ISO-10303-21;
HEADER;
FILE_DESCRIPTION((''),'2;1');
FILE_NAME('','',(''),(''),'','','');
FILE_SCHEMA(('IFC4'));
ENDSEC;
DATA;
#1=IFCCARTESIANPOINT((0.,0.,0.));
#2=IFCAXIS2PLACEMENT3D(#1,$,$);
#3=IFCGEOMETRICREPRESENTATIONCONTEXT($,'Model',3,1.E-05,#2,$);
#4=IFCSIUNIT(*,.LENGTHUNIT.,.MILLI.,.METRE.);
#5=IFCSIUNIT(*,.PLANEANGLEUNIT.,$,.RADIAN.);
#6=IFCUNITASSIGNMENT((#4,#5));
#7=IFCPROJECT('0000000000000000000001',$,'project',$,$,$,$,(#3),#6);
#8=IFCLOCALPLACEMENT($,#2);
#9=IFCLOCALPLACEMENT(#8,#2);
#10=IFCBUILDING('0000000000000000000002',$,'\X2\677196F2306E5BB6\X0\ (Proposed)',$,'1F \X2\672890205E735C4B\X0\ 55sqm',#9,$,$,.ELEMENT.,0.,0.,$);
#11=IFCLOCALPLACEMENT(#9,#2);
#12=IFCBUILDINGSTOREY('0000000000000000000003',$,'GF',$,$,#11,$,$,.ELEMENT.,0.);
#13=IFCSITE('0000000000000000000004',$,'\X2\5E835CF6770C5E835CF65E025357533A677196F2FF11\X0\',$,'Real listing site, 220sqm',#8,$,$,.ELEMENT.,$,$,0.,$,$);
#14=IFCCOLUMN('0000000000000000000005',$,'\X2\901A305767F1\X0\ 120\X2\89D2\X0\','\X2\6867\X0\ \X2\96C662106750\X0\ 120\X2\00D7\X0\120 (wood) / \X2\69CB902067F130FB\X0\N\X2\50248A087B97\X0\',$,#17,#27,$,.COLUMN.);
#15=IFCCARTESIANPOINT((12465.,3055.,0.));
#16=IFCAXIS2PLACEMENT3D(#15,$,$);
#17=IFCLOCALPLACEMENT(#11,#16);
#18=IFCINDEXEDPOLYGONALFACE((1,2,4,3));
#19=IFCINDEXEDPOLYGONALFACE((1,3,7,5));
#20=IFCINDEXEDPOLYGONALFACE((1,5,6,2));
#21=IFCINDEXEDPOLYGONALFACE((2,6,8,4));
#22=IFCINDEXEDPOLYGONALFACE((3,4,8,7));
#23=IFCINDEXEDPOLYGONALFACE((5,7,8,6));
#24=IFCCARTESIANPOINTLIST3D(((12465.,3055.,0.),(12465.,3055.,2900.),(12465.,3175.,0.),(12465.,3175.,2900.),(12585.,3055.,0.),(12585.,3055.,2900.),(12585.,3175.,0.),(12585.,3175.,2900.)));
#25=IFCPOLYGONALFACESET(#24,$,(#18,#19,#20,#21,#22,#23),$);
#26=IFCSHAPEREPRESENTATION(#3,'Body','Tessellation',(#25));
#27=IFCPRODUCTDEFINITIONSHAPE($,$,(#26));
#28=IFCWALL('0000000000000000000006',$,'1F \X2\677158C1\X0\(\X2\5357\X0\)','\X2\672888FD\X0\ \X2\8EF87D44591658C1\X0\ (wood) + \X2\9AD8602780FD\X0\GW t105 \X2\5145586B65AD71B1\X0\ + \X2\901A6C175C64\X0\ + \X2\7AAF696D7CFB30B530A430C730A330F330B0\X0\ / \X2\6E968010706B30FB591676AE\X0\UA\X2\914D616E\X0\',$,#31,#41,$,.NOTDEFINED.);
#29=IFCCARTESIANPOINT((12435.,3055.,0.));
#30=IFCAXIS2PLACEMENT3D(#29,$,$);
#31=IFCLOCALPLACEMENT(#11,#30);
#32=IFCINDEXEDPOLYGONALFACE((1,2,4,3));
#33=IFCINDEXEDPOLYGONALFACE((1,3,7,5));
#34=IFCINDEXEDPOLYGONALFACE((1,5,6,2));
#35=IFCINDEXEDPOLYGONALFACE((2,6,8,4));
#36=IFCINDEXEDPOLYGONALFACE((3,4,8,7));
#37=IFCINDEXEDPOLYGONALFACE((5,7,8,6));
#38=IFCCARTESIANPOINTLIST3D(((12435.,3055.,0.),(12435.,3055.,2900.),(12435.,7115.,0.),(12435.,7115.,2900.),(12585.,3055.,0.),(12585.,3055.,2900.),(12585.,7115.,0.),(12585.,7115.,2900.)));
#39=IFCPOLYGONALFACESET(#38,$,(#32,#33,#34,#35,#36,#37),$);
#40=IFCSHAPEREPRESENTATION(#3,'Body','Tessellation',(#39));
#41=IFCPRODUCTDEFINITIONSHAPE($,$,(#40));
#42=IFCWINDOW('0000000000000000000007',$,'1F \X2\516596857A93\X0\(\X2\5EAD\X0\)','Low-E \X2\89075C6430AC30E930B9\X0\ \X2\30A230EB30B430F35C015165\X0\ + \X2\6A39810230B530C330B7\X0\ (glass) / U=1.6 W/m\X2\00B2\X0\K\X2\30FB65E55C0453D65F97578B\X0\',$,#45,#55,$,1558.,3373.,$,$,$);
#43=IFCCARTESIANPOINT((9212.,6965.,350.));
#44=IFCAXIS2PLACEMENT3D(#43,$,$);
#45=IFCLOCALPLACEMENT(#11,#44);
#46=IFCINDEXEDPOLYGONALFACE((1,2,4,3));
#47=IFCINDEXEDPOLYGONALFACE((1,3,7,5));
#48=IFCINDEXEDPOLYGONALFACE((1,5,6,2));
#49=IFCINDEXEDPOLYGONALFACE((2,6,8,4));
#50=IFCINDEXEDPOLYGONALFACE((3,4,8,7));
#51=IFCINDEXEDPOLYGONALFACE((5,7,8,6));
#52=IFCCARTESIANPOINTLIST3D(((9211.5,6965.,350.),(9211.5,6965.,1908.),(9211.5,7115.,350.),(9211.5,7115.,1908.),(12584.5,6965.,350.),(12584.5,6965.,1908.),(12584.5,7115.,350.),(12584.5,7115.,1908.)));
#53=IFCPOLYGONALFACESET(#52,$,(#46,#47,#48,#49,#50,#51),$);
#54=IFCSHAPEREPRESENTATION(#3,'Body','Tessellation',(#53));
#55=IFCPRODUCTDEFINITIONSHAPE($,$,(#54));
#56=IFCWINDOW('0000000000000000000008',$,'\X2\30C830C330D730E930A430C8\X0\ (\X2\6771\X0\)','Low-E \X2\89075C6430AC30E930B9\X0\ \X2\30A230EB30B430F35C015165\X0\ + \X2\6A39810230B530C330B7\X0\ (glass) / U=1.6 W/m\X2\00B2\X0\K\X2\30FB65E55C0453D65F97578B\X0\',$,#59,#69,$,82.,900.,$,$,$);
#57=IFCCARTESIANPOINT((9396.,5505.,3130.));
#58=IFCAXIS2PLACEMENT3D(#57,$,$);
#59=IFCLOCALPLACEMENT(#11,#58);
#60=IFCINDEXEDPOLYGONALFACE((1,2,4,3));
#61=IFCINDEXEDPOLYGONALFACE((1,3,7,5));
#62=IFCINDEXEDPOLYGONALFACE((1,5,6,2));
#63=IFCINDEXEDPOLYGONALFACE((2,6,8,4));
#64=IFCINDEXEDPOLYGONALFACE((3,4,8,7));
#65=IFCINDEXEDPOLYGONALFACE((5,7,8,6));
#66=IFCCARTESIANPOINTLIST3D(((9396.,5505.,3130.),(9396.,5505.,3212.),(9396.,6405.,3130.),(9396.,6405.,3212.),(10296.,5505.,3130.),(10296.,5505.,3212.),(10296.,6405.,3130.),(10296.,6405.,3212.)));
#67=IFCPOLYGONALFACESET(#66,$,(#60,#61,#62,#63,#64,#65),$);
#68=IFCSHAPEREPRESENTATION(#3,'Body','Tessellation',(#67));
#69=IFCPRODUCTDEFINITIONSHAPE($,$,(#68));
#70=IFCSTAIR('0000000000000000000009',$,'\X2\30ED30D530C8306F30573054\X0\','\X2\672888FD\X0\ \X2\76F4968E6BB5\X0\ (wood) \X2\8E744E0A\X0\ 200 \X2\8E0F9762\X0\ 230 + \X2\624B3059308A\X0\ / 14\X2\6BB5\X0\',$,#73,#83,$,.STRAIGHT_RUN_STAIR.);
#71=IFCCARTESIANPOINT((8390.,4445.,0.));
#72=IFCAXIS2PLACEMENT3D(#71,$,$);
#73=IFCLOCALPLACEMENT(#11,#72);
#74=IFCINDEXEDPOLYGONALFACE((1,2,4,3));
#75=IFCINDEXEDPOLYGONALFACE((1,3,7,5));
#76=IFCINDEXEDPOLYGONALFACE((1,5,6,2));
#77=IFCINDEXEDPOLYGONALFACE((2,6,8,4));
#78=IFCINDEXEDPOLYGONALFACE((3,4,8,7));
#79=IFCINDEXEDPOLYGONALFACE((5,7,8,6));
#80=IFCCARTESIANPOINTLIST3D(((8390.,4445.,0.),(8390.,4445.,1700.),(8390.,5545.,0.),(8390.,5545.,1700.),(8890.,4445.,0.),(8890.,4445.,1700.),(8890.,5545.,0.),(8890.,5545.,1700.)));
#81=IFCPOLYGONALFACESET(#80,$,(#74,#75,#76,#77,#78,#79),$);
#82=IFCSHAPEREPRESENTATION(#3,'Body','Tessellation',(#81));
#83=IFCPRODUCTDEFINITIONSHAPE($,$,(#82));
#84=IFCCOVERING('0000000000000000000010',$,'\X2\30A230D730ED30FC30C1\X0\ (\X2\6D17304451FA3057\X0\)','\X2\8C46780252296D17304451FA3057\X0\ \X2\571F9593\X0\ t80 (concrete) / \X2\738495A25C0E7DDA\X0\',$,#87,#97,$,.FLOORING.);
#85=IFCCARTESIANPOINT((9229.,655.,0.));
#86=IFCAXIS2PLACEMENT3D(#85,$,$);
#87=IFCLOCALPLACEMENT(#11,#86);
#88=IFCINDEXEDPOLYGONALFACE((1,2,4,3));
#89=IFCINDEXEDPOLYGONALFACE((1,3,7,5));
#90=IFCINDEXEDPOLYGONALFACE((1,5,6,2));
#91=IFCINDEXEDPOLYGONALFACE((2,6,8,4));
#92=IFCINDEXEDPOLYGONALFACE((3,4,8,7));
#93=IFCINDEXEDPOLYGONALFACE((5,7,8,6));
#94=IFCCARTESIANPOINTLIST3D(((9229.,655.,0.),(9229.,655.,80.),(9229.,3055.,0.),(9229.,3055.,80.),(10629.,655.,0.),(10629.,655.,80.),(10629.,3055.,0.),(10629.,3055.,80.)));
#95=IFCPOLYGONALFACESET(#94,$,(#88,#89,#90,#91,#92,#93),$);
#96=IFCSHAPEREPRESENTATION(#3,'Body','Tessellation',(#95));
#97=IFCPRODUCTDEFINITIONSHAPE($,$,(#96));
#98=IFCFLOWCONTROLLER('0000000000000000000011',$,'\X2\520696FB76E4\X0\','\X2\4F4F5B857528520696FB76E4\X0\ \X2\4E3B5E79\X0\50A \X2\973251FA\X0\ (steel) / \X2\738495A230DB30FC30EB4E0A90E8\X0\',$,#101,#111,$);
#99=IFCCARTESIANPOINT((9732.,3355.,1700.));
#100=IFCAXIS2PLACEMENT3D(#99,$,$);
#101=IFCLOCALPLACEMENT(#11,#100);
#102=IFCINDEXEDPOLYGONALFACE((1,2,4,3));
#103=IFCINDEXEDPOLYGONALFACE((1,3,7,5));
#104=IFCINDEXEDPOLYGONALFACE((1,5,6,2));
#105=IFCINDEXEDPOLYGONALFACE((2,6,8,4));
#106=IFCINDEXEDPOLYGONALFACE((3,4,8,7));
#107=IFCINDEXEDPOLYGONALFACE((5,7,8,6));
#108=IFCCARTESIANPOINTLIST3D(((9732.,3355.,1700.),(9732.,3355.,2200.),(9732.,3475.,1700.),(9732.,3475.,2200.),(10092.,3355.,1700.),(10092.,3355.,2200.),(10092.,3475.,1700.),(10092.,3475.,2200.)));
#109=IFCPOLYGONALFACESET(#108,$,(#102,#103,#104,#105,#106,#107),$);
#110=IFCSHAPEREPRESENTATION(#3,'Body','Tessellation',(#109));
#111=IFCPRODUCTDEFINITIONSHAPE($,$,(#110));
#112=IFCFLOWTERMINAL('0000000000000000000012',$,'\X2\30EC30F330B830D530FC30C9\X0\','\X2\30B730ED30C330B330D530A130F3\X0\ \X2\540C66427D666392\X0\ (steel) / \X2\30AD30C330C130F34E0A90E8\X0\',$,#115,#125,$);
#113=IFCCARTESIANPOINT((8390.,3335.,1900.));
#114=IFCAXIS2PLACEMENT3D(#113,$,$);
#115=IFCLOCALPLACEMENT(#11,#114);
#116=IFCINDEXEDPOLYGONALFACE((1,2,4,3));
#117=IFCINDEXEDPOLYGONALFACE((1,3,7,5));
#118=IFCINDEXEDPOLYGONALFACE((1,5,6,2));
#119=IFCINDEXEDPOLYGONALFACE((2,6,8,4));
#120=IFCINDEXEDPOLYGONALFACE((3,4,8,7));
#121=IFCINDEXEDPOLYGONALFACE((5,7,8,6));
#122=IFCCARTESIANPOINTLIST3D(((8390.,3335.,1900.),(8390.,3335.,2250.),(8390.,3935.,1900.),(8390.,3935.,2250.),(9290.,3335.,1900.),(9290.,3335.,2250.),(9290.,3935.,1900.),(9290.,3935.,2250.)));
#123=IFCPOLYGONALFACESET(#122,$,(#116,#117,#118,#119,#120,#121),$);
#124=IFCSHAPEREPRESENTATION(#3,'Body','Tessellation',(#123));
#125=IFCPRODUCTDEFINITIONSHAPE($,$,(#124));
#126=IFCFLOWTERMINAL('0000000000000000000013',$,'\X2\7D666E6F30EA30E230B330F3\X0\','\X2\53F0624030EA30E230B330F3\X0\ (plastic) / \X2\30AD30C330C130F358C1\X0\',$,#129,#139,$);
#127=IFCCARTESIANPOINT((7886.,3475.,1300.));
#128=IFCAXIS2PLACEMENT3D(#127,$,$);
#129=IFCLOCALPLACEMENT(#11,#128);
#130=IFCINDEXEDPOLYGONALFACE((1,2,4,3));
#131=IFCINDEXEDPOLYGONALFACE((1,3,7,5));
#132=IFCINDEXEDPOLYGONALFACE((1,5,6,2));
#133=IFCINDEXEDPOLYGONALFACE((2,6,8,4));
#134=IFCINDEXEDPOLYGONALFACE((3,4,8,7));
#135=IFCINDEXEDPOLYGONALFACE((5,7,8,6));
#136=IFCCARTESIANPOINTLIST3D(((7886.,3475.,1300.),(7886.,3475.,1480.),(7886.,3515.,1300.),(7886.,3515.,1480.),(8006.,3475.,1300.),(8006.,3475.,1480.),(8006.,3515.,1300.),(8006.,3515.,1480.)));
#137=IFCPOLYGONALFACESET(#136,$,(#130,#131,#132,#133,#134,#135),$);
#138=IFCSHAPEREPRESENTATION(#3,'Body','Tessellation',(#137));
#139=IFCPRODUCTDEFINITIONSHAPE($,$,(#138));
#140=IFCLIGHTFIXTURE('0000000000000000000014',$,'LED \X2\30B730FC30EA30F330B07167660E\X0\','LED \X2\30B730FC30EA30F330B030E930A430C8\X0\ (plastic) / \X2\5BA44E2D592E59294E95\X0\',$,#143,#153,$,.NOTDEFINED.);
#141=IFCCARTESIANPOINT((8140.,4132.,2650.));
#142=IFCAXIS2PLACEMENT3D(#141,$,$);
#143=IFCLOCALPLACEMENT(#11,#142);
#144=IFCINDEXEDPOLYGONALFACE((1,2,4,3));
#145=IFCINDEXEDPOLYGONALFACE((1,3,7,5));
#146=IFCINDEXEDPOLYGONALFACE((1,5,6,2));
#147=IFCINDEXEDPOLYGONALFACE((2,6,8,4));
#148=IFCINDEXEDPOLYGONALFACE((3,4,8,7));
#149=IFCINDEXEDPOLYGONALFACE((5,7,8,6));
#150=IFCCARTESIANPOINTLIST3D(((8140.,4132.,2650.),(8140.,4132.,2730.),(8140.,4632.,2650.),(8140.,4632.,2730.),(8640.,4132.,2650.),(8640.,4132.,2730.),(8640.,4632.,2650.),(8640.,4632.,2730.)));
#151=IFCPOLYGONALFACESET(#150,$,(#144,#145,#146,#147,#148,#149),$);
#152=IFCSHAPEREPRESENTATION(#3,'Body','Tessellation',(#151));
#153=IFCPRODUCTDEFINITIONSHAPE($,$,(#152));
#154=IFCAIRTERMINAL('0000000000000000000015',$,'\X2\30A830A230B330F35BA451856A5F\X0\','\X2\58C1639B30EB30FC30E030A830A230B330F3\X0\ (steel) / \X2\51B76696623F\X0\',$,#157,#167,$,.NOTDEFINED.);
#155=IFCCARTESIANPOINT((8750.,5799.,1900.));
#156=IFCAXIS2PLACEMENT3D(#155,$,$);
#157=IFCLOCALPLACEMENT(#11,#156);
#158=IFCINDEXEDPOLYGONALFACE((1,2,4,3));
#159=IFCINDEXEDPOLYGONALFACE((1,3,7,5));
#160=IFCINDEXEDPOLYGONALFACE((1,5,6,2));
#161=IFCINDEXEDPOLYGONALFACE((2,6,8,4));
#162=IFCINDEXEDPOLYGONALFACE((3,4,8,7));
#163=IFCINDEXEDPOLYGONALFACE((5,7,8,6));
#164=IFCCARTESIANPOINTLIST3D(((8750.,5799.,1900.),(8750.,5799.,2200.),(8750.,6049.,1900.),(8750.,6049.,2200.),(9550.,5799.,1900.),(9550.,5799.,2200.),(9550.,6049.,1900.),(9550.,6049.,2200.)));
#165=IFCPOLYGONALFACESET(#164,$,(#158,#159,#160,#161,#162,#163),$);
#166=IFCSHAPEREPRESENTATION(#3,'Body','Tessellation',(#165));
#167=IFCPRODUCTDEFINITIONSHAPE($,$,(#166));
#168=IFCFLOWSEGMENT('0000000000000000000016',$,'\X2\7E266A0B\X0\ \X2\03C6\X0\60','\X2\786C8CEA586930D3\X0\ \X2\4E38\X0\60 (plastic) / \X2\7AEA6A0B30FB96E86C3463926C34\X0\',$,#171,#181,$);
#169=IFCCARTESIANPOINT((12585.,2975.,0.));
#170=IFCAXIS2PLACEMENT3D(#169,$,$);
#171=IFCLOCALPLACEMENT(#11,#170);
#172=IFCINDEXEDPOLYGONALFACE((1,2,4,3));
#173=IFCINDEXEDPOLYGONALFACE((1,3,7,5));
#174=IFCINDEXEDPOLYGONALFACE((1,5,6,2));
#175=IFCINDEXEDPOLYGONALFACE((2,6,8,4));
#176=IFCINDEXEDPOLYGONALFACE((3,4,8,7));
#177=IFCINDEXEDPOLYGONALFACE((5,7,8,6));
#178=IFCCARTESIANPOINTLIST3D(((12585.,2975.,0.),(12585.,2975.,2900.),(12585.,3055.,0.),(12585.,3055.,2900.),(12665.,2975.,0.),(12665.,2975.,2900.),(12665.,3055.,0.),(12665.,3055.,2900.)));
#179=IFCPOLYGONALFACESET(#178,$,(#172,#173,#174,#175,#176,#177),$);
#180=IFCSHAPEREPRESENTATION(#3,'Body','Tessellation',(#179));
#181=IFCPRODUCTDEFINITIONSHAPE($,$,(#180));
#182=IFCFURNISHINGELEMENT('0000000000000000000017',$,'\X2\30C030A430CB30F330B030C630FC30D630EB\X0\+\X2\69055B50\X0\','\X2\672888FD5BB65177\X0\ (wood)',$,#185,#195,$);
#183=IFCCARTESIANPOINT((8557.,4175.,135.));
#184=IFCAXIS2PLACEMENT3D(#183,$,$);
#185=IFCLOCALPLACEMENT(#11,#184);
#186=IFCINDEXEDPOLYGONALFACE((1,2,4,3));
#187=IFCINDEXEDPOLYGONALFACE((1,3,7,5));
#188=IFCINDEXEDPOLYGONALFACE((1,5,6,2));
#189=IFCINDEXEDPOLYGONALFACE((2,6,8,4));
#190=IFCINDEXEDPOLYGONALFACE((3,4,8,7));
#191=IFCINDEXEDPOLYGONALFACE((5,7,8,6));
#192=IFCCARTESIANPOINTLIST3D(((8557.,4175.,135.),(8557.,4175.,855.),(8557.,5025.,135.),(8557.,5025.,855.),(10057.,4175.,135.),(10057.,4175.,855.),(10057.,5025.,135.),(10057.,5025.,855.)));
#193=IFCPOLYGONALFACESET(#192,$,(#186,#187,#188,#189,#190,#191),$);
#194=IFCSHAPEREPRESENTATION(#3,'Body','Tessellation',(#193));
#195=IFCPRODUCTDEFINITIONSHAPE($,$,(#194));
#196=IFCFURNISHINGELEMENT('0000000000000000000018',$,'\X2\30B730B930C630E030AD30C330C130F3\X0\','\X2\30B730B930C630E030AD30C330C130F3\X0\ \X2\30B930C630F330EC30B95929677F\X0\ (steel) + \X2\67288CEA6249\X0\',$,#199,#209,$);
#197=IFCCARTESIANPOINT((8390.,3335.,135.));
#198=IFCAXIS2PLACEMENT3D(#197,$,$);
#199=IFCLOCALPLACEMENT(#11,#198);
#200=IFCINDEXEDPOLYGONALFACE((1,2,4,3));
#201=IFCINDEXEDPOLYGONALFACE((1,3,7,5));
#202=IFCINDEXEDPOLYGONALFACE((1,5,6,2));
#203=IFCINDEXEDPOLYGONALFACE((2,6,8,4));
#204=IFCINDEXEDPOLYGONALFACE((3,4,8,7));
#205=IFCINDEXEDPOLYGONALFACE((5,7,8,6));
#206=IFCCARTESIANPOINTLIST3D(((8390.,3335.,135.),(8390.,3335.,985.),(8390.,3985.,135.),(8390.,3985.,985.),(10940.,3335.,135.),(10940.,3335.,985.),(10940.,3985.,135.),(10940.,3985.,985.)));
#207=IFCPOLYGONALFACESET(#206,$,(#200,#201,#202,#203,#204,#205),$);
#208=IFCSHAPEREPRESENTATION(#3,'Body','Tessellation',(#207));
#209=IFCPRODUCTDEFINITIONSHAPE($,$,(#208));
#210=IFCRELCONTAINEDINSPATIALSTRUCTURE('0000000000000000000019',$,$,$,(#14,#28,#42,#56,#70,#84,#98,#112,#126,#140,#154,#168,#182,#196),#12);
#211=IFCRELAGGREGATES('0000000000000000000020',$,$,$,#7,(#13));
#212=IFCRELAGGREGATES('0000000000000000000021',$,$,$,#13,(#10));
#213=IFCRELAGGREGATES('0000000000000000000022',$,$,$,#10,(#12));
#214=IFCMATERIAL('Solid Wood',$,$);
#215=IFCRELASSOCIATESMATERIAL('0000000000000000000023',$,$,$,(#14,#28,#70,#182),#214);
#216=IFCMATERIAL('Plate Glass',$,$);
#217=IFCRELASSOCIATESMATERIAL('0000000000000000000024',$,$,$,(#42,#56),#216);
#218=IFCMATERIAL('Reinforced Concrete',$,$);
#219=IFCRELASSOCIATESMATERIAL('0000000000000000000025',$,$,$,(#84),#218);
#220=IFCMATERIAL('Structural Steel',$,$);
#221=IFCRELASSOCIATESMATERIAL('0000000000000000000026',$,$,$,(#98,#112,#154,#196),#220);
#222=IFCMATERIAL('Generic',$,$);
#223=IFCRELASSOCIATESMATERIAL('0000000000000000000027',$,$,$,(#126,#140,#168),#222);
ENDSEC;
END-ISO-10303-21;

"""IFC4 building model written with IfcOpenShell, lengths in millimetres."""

from ifc_helpers import new_model, si_unit, frame, frame_2d, origin, place, context, project, spatial, rectangle, extrude, material, element, fill, save


model = new_model("IFC4")

# Units and contexts
model_context = context("Model", 3, precision=1e-05, world=origin())
ifc_project = project(units=[si_unit("LENGTHUNIT", "METRE", prefix="MILLI"), si_unit("PLANEANGLEUNIT", "RADIAN")], contexts=[model_context])

# Site, building, storey
site_placement = place(None, origin())
site = spatial("IfcSite", under=ifc_project, at=site_placement, Name="広島県広島市南区東雲１", ObjectType="Real listing site, 220sqm", CompositionType="ELEMENT", RefElevation=0.0)
building_placement = place(site_placement, origin())
building = spatial("IfcBuilding", under=site, at=building_placement, Name="東雲の家 (Proposed)", ObjectType="1F 木造平屋 55sqm", CompositionType="ELEMENT", ElevationOfRefHeight=0.0, ElevationOfTerrain=0.0)
storey_placement = place(building_placement, origin())
storey = spatial("IfcBuildingStorey", under=building, at=storey_placement, Name="GF", CompositionType="ELEMENT", Elevation=0.0)

# Column
ifc_material_1 = material(Name="Solid Wood")
column_1_placement = place(storey_placement, frame((12465.0, 3055.0, 0.0)))
element("IfcColumn", 1, at=column_1_placement, inside=storey, material=ifc_material_1, Name="通し柱 120角", Description="桧 集成材 120×120 (wood) / 構造柱・N値計算", PredefinedType="COLUMN", context=model_context, shape_type="SweptSolid", body=[
    extrude(rectangle(XDim=120.0, YDim=120.0, at=frame_2d((60.0, 60.0))), frame((12465.0, 3055.0, 0.0)), (0.0, 0.0, 1.0), 2900.0),
])

# Wall, opening, window
wall_1_placement = place(storey_placement, frame((12435.0, 3055.0, 0.0)))
wall_1 = element("IfcWall", 2, at=wall_1_placement, inside=storey, material=ifc_material_1, Name="1F 東壁(南)", Description="木製 軸組外壁 (wood) + 高性能GW t105 充填断熱 + 通気層 + 窯業系サイディング / 準耐火・外皮UA配慮", PredefinedType="NOTDEFINED", context=model_context, shape_type="SweptSolid", body=[
    extrude(rectangle(XDim=150.0, YDim=4060.0, at=frame_2d((75.0, 2030.0))), frame((12435.0, 3055.0, 0.0)), (0.0, 0.0, 1.0), 2900.0),
])
opening_placement = place(storey_placement, frame((9212.0, 6965.0, 350.0)))
opening = element("IfcOpeningElement", 3, at=opening_placement, cuts=wall_1, PredefinedType="NOTDEFINED", context=model_context, shape_type="SweptSolid", body=[
    extrude(rectangle(XDim=3373.0, YDim=150.0, at=frame_2d((1686.0, 75.0))), frame((9212.0, 6965.0, 350.0)), (0.0, 0.0, 1.0), 1558.0),
])
ifc_material_2 = material(Name="Plate Glass")
window_1_placement = place(storey_placement, frame((9212.0, 6965.0, 350.0)))
window_1 = element("IfcWindow", 4, at=window_1_placement, inside=storey, material=ifc_material_2, Name="1F 入隅窓(庭)", Description="Low-E 複層ガラス アルゴン封入 + 樹脂サッシ (glass) / U=1.6 W/m²K・日射取得型", OverallHeight=1558.0, OverallWidth=3373.0, context=model_context, shape_type="SweptSolid", body=[
    extrude(rectangle(XDim=3373.0, YDim=150.0, at=frame_2d((1686.0, 75.0))), frame((9212.0, 6965.0, 350.0)), (0.0, 0.0, 1.0), 1558.0),
])
fill(opening, window_1)

# Window
window_2_placement = place(storey_placement, frame((9396.0, 5505.0, 3130.0)))
element("IfcWindow", 5, at=window_2_placement, inside=storey, material=ifc_material_2, Name="トップライト (東)", Description="Low-E 複層ガラス アルゴン封入 + 樹脂サッシ (glass) / U=1.6 W/m²K・日射取得型", OverallHeight=82.0, OverallWidth=900.0, context=model_context, shape_type="SweptSolid", body=[
    extrude(rectangle(XDim=900.0, YDim=900.0, at=frame_2d((450.0, 450.0))), frame((9396.0, 5505.0, 3130.0)), (0.0, 0.0, 1.0), 82.0),
])

# Stair
stair_placement = place(storey_placement, frame((8390.0, 4445.0, 0.0)))
element("IfcStair", 6, at=stair_placement, inside=storey, material=ifc_material_1, Name="ロフトはしご", Description="木製 直階段 (wood) 蹴上 200 踏面 230 + 手すり / 14段", PredefinedType="STRAIGHT_RUN_STAIR", context=model_context, shape_type="SweptSolid", body=[
    extrude(rectangle(XDim=500.0, YDim=1100.0, at=frame_2d((250.0, 550.0))), frame((8390.0, 4445.0, 0.0)), (0.0, 0.0, 1.0), 1700.0),
])

# Covering
ifc_material_3 = material(Name="Reinforced Concrete")
covering_placement = place(storey_placement, frame((9229.0, 655.0, 0.0)))
element("IfcCovering", 7, at=covering_placement, inside=storey, material=ifc_material_3, Name="アプローチ (洗い出し)", Description="豆砂利洗い出し 土間 t80 (concrete) / 玄関導線", PredefinedType="FLOORING", context=model_context, shape_type="SweptSolid", body=[
    extrude(rectangle(XDim=1400.0, YDim=2400.0, at=frame_2d((700.0, 1200.0))), frame((9229.0, 655.0, 0.0)), (0.0, 0.0, 1.0), 80.0),
])

# Flow controller
ifc_material_4 = material(Name="Structural Steel")
flow_controller_placement = place(storey_placement, frame((9732.0, 3355.0, 1700.0)))
element("IfcFlowController", 8, at=flow_controller_placement, inside=storey, material=ifc_material_4, Name="分電盤", Description="住宅用分電盤 主幹50A 露出 (steel) / 玄関ホール上部", context=model_context, shape_type="SweptSolid", body=[
    extrude(rectangle(XDim=360.0, YDim=120.0, at=frame_2d((180.0, 60.0))), frame((9732.0, 3355.0, 1700.0)), (0.0, 0.0, 1.0), 500.0),
])

# Flow terminals
flow_terminal_1_placement = place(storey_placement, frame((8390.0, 3335.0, 1900.0)))
element("IfcFlowTerminal", 9, at=flow_terminal_1_placement, inside=storey, material=ifc_material_4, Name="レンジフード", Description="シロッコファン 同時給排 (steel) / キッチン上部", context=model_context, shape_type="SweptSolid", body=[
    extrude(rectangle(XDim=900.0, YDim=600.0, at=frame_2d((450.0, 300.0))), frame((8390.0, 3335.0, 1900.0)), (0.0, 0.0, 1.0), 350.0),
])
ifc_material_5 = material(Name="Generic")
flow_terminal_2_placement = place(storey_placement, frame((7886.0, 3475.0, 1300.0)))
element("IfcFlowTerminal", 10, at=flow_terminal_2_placement, inside=storey, material=ifc_material_5, Name="給湯リモコン", Description="台所リモコン (plastic) / キッチン壁", context=model_context, shape_type="SweptSolid", body=[
    extrude(rectangle(XDim=120.0, YDim=40.0, at=frame_2d((60.0, 20.0))), frame((7886.0, 3475.0, 1300.0)), (0.0, 0.0, 1.0), 180.0),
])

# Light fixture
light_fixture_placement = place(storey_placement, frame((8140.0, 4132.0, 2650.0)))
element("IfcLightFixture", 11, at=light_fixture_placement, inside=storey, material=ifc_material_5, Name="LED シーリング照明", Description="LED シーリングライト (plastic) / 室中央天井", PredefinedType="NOTDEFINED", context=model_context, shape_type="SweptSolid", body=[
    extrude(rectangle(XDim=500.0, YDim=500.0, at=frame_2d((250.0, 250.0))), frame((8140.0, 4132.0, 2650.0)), (0.0, 0.0, 1.0), 80.0),
])

# Air terminal
air_terminal_placement = place(storey_placement, frame((8750.0, 5799.0, 1900.0)))
element("IfcAirTerminal", 12, at=air_terminal_placement, inside=storey, material=ifc_material_4, Name="エアコン室内機", Description="壁掛ルームエアコン (steel) / 冷暖房", PredefinedType="NOTDEFINED", context=model_context, shape_type="SweptSolid", body=[
    extrude(rectangle(XDim=800.0, YDim=250.0, at=frame_2d((400.0, 125.0))), frame((8750.0, 5799.0, 1900.0)), (0.0, 0.0, 1.0), 300.0),
])

# Flow segment
flow_segment_placement = place(storey_placement, frame((12585.0, 2975.0, 0.0)))
element("IfcFlowSegment", 13, at=flow_segment_placement, inside=storey, material=ifc_material_5, Name="縦樋 φ60", Description="硬質塩ビ 丸60 (plastic) / 竪樋・雨水排水", context=model_context, shape_type="SweptSolid", body=[
    extrude(rectangle(XDim=80.0, YDim=80.0, at=frame_2d((40.0, 40.0))), frame((12585.0, 2975.0, 0.0)), (0.0, 0.0, 1.0), 2900.0),
])

# Furnishing elements
furnishing_1_placement = place(storey_placement, frame((8557.0, 4175.0, 135.0)))
element("IfcFurnishingElement", 14, at=furnishing_1_placement, inside=storey, material=ifc_material_1, Name="ダイニングテーブル+椅子", Description="木製家具 (wood)", context=model_context, shape_type="SweptSolid", body=[
    extrude(rectangle(XDim=1500.0, YDim=850.0, at=frame_2d((750.0, 425.0))), frame((8557.0, 4175.0, 135.0)), (0.0, 0.0, 1.0), 720.0),
])
furnishing_2_placement = place(storey_placement, frame((8390.0, 3335.0, 135.0)))
element("IfcFurnishingElement", 15, at=furnishing_2_placement, inside=storey, material=ifc_material_4, Name="システムキッチン", Description="システムキッチン ステンレス天板 (steel) + 木質扉", context=model_context, shape_type="SweptSolid", body=[
    extrude(rectangle(XDim=2550.0, YDim=650.0, at=frame_2d((1275.0, 325.0))), frame((8390.0, 3335.0, 135.0)), (0.0, 0.0, 1.0), 850.0),
])

save(model, "model.ifc")
